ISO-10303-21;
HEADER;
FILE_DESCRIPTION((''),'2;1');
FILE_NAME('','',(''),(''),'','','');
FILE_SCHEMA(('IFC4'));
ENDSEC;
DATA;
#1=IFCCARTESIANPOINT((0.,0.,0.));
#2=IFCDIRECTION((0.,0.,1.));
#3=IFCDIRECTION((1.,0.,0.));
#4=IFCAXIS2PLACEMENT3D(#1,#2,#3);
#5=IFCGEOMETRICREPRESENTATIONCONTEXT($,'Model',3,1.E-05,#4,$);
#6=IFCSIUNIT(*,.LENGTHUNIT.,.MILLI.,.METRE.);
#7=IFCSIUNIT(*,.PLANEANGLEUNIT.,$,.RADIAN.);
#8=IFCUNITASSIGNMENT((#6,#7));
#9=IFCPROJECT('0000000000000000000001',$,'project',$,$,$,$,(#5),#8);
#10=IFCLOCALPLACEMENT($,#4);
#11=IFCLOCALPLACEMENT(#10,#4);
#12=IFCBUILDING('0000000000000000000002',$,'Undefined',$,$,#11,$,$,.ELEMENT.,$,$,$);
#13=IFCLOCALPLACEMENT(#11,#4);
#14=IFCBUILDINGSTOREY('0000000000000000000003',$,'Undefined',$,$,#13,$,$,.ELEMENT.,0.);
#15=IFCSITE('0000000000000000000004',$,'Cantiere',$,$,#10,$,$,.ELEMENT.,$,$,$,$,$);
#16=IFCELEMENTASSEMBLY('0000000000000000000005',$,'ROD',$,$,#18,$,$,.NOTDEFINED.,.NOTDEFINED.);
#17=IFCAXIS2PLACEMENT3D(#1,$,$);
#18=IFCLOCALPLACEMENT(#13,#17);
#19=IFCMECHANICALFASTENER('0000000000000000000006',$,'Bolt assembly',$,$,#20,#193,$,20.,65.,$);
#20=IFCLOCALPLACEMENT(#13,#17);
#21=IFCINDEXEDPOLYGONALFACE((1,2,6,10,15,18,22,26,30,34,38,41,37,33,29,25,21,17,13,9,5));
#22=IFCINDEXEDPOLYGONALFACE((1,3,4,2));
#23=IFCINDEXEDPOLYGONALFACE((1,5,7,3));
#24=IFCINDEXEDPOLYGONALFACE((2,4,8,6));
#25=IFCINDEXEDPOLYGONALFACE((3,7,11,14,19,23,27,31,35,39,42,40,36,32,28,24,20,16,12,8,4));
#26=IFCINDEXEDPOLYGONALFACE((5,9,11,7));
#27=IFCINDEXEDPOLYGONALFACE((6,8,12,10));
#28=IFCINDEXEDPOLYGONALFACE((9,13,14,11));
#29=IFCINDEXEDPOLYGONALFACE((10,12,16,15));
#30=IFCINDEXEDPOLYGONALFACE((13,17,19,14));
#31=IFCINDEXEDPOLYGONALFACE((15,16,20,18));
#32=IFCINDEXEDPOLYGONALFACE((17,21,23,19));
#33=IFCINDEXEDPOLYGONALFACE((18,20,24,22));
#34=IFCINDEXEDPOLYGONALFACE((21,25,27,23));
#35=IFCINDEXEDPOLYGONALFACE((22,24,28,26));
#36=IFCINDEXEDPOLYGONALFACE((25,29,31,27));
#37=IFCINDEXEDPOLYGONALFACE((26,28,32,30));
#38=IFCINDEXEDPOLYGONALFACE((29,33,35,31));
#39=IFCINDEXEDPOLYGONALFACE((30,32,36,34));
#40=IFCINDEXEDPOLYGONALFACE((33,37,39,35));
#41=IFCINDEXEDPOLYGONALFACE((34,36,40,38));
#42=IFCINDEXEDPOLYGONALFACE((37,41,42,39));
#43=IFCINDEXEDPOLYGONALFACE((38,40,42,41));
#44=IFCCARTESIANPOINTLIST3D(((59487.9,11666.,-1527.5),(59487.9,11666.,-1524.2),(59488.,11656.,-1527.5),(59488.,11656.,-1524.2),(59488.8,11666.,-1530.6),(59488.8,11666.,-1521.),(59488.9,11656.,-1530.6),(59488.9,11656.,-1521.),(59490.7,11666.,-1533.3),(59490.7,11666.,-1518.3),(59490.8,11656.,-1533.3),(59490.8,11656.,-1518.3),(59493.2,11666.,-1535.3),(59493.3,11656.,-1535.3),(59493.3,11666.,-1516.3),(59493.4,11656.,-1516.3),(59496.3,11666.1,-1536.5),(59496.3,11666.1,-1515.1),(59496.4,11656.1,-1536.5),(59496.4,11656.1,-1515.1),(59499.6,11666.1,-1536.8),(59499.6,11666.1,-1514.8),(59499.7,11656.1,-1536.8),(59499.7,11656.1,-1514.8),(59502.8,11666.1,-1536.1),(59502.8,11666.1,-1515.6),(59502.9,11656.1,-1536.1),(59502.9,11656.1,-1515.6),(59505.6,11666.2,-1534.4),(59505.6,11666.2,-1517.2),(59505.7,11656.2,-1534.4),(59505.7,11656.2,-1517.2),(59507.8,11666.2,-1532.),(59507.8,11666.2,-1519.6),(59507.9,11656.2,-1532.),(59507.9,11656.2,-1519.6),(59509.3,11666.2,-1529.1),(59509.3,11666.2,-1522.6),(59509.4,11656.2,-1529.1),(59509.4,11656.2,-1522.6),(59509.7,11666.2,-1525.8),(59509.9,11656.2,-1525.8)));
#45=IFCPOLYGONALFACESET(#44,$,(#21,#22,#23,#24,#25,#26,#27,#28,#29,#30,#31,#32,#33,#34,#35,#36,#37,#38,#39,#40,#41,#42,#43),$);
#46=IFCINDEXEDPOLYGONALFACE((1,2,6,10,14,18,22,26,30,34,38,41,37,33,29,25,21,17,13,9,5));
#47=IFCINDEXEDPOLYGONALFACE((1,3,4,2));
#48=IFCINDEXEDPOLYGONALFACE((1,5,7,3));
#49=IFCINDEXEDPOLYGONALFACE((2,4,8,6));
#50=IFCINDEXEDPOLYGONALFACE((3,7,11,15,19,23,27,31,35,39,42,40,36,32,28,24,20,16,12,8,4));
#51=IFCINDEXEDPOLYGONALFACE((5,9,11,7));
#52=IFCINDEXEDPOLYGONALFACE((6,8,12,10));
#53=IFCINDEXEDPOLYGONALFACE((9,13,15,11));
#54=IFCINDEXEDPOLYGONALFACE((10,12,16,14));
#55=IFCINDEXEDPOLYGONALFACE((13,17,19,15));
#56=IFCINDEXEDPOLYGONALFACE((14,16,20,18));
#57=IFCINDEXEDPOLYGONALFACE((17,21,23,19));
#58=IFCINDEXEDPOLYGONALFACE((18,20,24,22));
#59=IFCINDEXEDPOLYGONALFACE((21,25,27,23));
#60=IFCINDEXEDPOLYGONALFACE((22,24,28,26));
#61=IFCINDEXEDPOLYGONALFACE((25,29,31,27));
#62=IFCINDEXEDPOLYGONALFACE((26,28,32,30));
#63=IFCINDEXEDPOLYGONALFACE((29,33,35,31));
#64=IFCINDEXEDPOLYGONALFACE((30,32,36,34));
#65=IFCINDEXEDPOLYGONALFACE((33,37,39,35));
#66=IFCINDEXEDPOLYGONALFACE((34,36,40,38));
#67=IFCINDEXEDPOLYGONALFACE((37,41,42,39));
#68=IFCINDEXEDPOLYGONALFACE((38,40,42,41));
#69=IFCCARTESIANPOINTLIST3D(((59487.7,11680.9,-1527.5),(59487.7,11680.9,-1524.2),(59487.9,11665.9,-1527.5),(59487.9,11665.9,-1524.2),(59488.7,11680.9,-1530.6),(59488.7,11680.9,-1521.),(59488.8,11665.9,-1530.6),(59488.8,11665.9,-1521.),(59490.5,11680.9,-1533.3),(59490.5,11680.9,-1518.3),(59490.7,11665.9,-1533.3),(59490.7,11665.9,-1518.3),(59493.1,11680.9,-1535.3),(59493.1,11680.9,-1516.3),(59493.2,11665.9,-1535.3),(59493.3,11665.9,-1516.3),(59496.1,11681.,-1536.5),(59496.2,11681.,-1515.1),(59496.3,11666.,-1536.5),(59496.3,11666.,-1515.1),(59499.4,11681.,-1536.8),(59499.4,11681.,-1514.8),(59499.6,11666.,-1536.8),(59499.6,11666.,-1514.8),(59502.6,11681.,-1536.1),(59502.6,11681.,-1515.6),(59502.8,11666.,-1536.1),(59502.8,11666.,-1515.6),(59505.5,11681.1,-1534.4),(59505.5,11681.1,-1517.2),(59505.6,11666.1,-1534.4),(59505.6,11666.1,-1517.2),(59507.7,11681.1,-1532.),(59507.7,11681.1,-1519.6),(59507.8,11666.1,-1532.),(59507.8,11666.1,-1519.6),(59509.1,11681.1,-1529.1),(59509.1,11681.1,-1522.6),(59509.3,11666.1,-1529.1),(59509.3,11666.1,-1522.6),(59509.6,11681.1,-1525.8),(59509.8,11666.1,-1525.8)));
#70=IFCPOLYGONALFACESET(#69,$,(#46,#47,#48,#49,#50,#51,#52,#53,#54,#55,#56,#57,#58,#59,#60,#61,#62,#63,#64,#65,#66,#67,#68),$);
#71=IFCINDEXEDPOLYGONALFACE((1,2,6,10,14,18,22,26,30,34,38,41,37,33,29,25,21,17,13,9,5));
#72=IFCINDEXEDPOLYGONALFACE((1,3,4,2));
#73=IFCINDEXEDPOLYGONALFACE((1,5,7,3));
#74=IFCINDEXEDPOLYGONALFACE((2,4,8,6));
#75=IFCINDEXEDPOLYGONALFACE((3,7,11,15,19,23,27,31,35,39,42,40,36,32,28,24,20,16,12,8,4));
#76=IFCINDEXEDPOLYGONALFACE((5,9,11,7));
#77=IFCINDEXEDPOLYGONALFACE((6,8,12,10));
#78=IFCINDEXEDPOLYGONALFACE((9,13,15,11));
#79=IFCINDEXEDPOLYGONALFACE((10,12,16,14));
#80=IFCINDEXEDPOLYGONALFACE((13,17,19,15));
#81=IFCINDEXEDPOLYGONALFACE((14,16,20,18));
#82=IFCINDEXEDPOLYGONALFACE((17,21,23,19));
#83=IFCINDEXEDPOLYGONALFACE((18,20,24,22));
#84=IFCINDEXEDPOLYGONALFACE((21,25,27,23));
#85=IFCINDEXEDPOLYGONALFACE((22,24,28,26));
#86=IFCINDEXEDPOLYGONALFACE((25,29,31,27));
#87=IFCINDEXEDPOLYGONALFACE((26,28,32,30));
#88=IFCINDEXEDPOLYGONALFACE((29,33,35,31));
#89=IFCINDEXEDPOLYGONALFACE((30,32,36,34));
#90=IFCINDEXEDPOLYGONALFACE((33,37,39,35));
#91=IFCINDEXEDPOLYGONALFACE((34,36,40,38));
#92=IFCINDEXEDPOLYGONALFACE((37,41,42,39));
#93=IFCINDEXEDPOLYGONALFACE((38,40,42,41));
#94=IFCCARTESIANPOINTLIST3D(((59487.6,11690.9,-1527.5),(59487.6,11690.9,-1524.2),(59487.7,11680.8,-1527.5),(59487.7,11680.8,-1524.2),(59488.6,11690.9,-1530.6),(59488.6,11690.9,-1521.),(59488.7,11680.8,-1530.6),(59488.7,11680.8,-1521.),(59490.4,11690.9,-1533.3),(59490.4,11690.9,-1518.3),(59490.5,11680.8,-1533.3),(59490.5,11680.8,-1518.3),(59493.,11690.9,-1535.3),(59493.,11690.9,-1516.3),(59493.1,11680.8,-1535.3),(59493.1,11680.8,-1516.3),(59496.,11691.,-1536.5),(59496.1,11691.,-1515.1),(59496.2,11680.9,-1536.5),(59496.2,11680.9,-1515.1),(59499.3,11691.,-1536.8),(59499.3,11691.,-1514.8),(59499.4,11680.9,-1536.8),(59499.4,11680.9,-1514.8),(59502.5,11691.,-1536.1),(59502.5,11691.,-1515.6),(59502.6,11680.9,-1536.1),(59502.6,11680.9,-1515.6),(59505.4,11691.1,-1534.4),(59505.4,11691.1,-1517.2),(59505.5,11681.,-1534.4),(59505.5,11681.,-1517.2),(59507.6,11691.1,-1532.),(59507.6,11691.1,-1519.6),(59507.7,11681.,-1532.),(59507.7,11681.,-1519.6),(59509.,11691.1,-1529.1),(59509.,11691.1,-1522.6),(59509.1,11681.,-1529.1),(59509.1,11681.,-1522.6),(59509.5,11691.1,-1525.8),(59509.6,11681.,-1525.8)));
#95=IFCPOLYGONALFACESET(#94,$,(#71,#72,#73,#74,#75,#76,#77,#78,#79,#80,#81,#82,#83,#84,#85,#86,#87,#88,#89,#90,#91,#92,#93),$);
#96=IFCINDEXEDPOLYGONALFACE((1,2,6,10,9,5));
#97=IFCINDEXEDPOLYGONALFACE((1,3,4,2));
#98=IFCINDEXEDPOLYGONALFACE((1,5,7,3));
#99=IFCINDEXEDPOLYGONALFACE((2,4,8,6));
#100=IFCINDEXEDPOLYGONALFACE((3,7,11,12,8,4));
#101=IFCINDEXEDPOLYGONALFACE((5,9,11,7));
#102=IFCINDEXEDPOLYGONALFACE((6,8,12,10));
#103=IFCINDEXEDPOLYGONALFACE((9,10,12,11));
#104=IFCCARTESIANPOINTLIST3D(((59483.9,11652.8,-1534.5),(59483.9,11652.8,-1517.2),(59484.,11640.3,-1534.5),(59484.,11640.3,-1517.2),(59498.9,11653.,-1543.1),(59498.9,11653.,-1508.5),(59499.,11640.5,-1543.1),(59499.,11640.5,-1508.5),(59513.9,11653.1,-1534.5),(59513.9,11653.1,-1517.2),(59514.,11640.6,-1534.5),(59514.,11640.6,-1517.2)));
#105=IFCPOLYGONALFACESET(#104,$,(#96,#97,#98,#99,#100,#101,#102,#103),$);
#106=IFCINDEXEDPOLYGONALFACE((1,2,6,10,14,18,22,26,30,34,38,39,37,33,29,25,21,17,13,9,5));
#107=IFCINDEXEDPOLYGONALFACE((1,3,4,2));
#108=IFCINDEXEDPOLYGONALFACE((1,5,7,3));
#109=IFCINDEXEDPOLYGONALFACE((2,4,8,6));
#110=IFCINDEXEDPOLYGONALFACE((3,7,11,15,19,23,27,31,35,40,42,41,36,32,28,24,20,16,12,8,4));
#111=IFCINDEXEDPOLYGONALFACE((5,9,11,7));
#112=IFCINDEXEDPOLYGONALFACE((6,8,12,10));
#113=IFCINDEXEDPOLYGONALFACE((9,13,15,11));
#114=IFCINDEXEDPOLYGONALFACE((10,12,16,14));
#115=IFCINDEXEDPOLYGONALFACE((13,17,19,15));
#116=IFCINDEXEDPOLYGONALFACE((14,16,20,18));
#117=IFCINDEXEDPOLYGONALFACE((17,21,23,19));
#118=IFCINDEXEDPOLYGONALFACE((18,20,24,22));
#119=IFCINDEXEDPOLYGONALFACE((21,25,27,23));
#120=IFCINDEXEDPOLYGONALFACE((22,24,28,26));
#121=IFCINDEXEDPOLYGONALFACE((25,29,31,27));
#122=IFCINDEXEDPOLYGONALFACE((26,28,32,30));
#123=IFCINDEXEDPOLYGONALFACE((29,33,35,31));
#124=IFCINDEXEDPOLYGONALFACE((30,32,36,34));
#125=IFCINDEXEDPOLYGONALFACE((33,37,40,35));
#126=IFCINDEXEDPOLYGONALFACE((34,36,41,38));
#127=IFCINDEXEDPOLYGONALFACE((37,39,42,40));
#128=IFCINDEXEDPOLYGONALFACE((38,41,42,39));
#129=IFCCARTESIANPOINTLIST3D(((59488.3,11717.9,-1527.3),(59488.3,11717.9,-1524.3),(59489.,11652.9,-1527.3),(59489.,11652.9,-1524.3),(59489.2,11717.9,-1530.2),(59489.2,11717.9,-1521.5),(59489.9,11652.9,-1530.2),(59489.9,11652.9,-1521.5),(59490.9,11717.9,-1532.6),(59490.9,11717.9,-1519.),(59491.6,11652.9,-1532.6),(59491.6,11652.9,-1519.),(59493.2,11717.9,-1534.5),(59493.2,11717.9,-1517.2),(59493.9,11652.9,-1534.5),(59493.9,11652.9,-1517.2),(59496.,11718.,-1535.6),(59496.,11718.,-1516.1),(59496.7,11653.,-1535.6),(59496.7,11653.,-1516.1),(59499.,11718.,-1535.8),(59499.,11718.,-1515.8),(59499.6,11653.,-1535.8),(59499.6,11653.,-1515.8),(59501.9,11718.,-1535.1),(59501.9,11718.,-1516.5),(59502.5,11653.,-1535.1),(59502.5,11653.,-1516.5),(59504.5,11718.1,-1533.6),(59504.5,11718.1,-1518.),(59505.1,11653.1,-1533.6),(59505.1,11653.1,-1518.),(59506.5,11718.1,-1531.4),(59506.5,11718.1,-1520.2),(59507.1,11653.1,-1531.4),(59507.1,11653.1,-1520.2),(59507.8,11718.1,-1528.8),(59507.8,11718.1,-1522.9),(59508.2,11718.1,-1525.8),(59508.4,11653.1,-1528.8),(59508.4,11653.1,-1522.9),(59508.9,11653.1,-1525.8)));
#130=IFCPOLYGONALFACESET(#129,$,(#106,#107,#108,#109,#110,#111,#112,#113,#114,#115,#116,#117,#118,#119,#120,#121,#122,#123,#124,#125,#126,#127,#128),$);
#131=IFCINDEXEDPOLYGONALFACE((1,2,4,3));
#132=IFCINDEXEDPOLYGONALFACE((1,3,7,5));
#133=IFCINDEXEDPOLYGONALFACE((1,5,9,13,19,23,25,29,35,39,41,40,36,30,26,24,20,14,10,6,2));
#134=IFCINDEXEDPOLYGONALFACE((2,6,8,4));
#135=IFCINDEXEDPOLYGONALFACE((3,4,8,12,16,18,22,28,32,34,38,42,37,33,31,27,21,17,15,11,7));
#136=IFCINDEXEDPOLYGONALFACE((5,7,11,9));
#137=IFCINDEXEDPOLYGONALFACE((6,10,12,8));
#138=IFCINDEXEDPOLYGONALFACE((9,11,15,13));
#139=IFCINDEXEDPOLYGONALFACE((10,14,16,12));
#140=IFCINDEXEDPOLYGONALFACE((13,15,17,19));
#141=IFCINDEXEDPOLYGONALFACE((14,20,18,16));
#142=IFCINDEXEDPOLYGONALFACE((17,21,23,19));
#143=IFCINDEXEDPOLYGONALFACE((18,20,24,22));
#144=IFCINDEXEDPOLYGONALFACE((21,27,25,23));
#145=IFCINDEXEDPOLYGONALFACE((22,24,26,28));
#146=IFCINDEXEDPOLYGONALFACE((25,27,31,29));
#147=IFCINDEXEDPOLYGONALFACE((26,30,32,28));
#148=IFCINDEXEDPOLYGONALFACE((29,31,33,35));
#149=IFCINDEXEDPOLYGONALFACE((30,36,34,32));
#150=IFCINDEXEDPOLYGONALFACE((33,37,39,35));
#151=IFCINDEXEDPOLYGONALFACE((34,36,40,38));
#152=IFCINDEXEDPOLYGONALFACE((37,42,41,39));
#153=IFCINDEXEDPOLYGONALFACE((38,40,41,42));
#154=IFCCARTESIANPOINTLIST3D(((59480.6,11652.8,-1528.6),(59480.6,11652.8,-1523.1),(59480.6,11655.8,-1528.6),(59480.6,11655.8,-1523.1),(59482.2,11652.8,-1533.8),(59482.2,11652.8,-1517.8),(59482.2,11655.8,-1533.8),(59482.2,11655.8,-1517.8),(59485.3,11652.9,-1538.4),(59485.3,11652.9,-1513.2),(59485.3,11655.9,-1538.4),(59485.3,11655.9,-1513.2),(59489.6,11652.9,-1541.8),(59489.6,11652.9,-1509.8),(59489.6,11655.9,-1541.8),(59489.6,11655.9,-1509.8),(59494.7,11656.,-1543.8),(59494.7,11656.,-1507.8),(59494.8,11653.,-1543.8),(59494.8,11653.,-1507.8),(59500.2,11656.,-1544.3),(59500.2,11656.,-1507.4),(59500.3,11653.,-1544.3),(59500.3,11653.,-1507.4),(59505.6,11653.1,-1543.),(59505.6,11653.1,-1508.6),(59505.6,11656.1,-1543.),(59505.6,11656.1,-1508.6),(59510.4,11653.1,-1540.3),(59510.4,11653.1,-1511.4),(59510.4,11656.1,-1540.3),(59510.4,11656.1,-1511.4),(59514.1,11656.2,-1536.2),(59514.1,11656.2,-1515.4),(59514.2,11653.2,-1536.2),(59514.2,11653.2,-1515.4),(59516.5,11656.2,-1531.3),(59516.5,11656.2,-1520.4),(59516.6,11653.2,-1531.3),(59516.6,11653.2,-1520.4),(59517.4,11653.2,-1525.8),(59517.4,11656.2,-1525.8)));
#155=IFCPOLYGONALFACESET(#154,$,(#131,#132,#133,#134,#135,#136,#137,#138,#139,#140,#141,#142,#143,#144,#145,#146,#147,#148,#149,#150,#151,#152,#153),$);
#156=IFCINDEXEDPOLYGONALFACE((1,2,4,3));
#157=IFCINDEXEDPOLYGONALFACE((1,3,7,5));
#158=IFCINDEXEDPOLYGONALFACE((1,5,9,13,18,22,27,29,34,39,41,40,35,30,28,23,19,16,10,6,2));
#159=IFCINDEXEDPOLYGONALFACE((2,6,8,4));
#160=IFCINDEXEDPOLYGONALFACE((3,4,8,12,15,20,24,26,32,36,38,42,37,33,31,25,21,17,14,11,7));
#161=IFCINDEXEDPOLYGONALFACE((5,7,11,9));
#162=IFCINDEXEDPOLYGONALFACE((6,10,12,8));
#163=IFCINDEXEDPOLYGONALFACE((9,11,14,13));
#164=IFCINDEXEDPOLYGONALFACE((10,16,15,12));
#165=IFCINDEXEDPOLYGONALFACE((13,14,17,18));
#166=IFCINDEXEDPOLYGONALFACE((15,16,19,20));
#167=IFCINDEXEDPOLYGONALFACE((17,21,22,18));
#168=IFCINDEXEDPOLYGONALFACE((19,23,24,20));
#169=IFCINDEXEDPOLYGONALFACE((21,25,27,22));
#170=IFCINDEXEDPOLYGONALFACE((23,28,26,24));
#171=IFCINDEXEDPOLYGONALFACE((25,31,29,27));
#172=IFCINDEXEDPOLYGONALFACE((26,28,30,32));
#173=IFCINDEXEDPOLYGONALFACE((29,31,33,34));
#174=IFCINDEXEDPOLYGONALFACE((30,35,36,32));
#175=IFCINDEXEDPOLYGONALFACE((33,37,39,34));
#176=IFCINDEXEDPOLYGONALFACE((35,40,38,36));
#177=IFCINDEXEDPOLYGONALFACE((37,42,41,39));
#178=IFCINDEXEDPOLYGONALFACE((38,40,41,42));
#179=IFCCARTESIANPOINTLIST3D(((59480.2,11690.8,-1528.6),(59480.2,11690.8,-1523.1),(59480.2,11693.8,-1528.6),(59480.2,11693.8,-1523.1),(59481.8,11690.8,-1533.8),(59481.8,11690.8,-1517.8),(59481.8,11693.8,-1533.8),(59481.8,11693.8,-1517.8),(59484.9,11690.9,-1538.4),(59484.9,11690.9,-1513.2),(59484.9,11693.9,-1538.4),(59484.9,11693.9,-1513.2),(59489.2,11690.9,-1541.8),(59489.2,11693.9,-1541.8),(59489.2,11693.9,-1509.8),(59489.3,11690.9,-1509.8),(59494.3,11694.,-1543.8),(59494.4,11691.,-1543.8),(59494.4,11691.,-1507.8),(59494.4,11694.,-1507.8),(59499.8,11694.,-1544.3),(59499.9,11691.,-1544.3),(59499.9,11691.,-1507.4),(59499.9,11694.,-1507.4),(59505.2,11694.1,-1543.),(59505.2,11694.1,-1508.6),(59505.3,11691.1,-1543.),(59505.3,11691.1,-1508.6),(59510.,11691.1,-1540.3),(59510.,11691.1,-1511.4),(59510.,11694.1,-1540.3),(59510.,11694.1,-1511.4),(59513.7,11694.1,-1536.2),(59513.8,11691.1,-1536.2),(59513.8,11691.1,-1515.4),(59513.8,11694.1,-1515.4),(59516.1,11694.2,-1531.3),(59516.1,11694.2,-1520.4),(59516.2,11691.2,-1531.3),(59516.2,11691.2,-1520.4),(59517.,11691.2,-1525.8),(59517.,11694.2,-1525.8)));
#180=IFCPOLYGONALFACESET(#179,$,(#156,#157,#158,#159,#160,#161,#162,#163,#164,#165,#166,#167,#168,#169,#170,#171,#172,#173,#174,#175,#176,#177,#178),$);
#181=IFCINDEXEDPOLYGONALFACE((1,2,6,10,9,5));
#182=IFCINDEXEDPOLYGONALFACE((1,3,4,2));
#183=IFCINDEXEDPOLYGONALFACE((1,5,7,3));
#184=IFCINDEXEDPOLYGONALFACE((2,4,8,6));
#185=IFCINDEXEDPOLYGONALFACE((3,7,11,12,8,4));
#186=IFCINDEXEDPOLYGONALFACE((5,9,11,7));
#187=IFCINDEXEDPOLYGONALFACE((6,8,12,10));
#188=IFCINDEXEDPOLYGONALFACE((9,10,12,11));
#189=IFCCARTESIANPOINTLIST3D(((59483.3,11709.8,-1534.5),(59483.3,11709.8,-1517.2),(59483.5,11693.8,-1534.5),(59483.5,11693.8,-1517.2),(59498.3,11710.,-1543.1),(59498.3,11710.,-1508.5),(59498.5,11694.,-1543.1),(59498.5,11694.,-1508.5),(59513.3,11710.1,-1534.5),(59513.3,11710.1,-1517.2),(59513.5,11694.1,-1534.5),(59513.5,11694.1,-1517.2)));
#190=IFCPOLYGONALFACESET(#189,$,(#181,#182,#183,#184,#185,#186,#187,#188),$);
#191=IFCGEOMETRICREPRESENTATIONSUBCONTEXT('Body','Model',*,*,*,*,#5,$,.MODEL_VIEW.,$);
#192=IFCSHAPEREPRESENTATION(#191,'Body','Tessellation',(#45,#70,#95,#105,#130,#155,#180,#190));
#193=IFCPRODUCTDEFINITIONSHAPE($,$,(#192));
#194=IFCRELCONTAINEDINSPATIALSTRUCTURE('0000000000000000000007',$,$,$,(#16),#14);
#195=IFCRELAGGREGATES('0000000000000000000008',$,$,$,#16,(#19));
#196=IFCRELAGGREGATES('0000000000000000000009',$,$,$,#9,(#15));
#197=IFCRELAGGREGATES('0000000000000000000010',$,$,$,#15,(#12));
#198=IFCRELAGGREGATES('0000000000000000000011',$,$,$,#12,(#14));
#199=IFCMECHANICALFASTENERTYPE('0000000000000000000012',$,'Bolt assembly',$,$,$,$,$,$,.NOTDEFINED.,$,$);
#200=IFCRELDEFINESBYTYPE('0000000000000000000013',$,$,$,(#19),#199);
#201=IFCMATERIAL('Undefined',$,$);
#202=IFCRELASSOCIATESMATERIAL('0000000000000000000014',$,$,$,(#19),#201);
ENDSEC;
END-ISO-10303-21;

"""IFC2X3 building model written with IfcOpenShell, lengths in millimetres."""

from ifc_helpers import new_model, si_unit, frame, origin_with_axes, origin_2d_with_axis, place, context, subcontext, project, spatial, polyline, circle, outline, extrude, source, transform, mapped, material, type_object, element, aggregate, save


model = new_model("IFC2X3")

# Units and contexts
model_context = context("Model", 3, precision=1e-05, world=origin_with_axes())
body_context = subcontext(model_context, "Body", "Model", "MODEL_VIEW")
ifc_project = project(units=[si_unit("LENGTHUNIT", "METRE", prefix="MILLI"), si_unit("PLANEANGLEUNIT", "RADIAN")], contexts=[model_context])

# Site, building, storey
site_placement = place(None, origin_with_axes())
site = spatial("IfcSite", under=ifc_project, at=site_placement, Name="Cantiere", CompositionType="ELEMENT")
building_placement = place(site_placement, origin_with_axes())
building = spatial("IfcBuilding", under=site, at=building_placement, Name="Undefined", CompositionType="ELEMENT")
storey_placement = place(building_placement, origin_with_axes())
storey = spatial("IfcBuildingStorey", under=building, at=storey_placement, Name="Undefined", CompositionType="ELEMENT", Elevation=0.0)

# Element assembly
assembly_1_placement = place(storey_placement, origin_with_axes())
assembly_1 = element("IfcElementAssembly", 1, at=assembly_1_placement, inside=storey, Name="ROD", AssemblyPlace="NOTDEFINED", PredefinedType="NOTDEFINED")

# Mechanical fastener
ifc_material_1 = material(Name="Undefined")
mechanical_fastener_type = type_object("IfcMechanicalFastenerType", Name="Bolt assembly")
shared_shape_1 = source(origin_with_axes(), body_context, "Body", "SweptSolid", [
    extrude(circle(Radius=11.0, at=origin_2d_with_axis()), frame((0.0, 0.1, 0.0), z_axis=(0.0, 1.0, 0.0), x_axis=(1.0, 0.0, 0.0)), (0.0, 0.0, 1.0), 10.0),
    extrude(circle(Radius=11.0, at=origin_2d_with_axis()), frame((0.0, 10.0, 0.0), z_axis=(0.0, 1.0, 0.0), x_axis=(1.0, 0.0, 0.0)), (0.0, 0.0, 1.0), 15.0),
    extrude(circle(Radius=11.0, at=origin_2d_with_axis()), frame((0.0, 24.9, 0.0), z_axis=(0.0, 1.0, 0.0), x_axis=(1.0, 0.0, 0.0)), (0.0, 0.0, 1.0), 10.1),
    extrude(outline(polyline([(15.0, -8.7), (15.0, 8.7), (0.0, 17.3), (-15.0, 8.7), (-15.0, -8.7), (0.0, -17.3), (15.0, -8.7)])), frame((0.0, -15.5, 0.0), z_axis=(0.0, 1.0, 0.0), x_axis=(1.0, 0.0, 0.0)), (0.0, 0.0, 1.0), 12.5),
    extrude(circle(Radius=10.0, at=origin_2d_with_axis()), frame((0.0, -3.0, 0.0), z_axis=(0.0, 1.0, 0.0), x_axis=(1.0, 0.0, 0.0)), (0.0, 0.0, 1.0), 65.0),
    extrude(circle(Radius=18.5, at=origin_2d_with_axis()), frame((0.0, -3.0, 0.0), z_axis=(0.0, 1.0, 0.0), x_axis=(1.0, 0.0, 0.0)), (0.0, 0.0, 1.0), 3.0),
    extrude(circle(Radius=18.5, at=origin_2d_with_axis()), frame((0.0, 35.0, 0.0), z_axis=(0.0, 1.0, 0.0), x_axis=(1.0, 0.0, 0.0)), (0.0, 0.0, 1.0), 3.0),
    extrude(outline(polyline([(15.0, -8.7), (15.0, 8.7), (0.0, 17.3), (-15.0, 8.7), (-15.0, -8.7), (0.0, -17.3), (15.0, -8.7)])), frame((0.0, 38.0, 0.0), z_axis=(0.0, 1.0, 0.0), x_axis=(1.0, 0.0, 0.0)), (0.0, 0.0, 1.0), 16.0),
])
mechanical_fastener_1_placement = place(assembly_1_placement, frame((59498.9, 11656.0, -1525.8), z_axis=(0.000205, 0.000002, 1.0), x_axis=(0.999949, 0.010137, -0.000205)))
mechanical_fastener_1 = element("IfcMechanicalFastener", 2, at=mechanical_fastener_1_placement, type_object=mechanical_fastener_type, material=ifc_material_1, Name="Bolt assembly", NominalDiameter=20.0, NominalLength=65.0, context=body_context, shape_type="MappedRepresentation", body=[
    mapped(shared_shape_1, transform((0.0, 0.0, 0.0))),
])
aggregate(assembly_1, [mechanical_fastener_1])

save(model, "model.ifc")
